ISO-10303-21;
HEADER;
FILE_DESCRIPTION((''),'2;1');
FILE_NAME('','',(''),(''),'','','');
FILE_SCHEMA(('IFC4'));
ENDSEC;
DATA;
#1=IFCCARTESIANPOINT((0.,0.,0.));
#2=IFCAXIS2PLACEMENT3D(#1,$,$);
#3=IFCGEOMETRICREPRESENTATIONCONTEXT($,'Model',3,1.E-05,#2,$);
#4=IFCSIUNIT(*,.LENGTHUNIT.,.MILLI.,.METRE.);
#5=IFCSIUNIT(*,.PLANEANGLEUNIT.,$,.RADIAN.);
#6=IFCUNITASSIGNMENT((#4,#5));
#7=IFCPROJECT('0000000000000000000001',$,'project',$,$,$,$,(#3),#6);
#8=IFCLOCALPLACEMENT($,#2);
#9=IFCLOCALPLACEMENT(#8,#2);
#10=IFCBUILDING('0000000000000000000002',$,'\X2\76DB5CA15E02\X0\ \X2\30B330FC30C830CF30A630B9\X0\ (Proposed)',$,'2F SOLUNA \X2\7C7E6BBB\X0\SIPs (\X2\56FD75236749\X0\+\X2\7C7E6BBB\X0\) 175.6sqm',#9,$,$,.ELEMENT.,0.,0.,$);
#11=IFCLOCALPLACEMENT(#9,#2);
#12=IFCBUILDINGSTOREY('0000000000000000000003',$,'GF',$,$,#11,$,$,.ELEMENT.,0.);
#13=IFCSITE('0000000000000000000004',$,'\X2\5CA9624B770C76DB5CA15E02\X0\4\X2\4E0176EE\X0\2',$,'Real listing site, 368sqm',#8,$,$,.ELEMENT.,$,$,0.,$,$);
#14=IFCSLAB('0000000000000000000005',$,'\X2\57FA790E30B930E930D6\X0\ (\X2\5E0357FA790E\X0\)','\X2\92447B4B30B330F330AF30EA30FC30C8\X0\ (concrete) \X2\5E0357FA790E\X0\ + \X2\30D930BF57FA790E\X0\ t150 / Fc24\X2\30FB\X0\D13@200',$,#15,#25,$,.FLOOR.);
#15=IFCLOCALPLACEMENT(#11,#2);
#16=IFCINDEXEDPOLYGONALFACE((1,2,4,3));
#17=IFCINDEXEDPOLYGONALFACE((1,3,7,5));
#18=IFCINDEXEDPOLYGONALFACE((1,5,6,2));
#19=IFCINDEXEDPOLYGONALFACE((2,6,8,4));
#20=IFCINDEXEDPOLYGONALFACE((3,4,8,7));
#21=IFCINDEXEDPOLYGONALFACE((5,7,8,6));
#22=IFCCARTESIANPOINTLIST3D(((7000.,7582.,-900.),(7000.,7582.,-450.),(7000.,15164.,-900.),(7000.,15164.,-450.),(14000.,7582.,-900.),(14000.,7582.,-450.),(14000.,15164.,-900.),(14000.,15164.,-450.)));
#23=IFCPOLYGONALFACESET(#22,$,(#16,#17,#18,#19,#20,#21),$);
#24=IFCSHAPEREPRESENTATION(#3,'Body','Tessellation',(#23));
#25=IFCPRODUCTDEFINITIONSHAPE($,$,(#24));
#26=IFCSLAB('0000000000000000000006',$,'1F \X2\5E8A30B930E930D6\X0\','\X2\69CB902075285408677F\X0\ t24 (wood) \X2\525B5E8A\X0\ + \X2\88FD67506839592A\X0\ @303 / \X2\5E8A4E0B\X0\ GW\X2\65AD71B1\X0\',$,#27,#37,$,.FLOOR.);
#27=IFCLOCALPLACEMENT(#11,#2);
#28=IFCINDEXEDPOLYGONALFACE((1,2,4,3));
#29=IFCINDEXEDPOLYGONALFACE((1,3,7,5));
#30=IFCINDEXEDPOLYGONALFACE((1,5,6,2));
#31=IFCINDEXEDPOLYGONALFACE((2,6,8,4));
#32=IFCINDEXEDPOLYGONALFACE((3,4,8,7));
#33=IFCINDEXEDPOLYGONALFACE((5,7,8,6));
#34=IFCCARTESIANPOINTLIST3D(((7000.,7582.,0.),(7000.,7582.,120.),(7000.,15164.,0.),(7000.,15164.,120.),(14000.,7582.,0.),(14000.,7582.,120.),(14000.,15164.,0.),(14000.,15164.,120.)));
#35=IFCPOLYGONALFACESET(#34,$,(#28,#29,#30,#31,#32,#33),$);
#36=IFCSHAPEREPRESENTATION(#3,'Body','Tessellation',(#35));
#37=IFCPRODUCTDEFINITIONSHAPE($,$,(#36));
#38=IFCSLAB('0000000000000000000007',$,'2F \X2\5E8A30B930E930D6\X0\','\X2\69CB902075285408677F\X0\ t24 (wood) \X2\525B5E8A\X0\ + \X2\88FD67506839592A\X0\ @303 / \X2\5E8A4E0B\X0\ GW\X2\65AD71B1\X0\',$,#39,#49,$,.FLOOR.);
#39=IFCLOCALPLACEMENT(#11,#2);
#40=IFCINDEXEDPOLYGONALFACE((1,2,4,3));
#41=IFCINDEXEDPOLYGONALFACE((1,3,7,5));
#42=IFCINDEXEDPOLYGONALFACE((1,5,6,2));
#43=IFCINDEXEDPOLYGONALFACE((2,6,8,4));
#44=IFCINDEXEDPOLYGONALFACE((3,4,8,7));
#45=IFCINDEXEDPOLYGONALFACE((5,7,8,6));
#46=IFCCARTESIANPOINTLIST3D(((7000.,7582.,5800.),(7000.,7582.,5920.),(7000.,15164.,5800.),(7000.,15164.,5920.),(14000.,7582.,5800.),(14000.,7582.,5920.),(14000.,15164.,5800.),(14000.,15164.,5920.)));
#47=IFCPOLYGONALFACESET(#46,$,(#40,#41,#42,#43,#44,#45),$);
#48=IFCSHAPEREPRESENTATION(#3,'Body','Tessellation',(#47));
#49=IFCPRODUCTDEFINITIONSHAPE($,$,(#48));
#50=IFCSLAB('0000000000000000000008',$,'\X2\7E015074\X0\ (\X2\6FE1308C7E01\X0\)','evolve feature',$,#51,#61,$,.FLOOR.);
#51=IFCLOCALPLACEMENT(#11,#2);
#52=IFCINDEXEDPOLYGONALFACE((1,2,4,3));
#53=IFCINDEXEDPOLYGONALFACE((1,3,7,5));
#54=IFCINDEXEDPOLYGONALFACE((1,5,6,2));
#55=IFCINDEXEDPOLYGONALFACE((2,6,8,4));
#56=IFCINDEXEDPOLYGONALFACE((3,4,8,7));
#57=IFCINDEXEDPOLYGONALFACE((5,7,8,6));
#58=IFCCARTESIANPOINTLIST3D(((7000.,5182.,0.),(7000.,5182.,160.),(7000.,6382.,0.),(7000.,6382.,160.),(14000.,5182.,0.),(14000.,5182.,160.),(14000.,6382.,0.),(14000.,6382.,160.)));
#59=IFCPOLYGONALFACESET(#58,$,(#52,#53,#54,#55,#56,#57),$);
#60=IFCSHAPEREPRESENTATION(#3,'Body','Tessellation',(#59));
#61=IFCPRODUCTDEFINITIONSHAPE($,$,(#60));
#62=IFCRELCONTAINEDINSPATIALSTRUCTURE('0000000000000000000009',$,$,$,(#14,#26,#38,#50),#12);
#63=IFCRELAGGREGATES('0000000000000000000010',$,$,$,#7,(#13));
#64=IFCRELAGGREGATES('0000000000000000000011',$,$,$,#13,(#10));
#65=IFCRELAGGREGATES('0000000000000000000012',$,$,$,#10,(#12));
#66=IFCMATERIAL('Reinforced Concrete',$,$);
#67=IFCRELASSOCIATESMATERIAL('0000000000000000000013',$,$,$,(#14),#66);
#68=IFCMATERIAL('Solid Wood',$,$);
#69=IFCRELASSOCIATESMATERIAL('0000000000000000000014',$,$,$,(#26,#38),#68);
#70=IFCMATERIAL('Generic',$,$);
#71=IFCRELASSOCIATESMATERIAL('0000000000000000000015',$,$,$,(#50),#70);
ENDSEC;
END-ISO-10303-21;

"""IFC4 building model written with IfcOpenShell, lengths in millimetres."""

from ifc_helpers import new_model, si_unit, frame, frame_2d, origin, place, context, project, spatial, rectangle, extrude, material, element, save


model = new_model("IFC4")

# Units and contexts
model_context = context("Model", 3, precision=1e-05, world=origin())
ifc_project = project(units=[si_unit("LENGTHUNIT", "METRE", prefix="MILLI"), si_unit("PLANEANGLEUNIT", "RADIAN")], contexts=[model_context])

# Site, building, storey
site_placement = place(None, origin())
site = spatial("IfcSite", under=ifc_project, at=site_placement, Name="岩手県盛岡市4丁目2", ObjectType="Real listing site, 368sqm", CompositionType="ELEMENT", RefElevation=0.0)
building_placement = place(site_placement, origin())
building = spatial("IfcBuilding", under=site, at=building_placement, Name="盛岡市 コートハウス (Proposed)", ObjectType="2F SOLUNA 籾殻SIPs (国産杉+籾殻) 175.6sqm", CompositionType="ELEMENT", ElevationOfRefHeight=0.0, ElevationOfTerrain=0.0)
storey_placement = place(building_placement, origin())
storey = spatial("IfcBuildingStorey", under=building, at=storey_placement, Name="GF", CompositionType="ELEMENT", Elevation=0.0)

# Slabs
ifc_material_1 = material(Name="Reinforced Concrete")
slab_1_placement = place(storey_placement, frame((3500.0, 3791.0, -450.0)))
element("IfcSlab", 1, at=slab_1_placement, inside=storey, material=ifc_material_1, Name="基礎スラブ (布基礎)", Description="鉄筋コンクリート (concrete) 布基礎 + ベタ基礎 t150 / Fc24・D13@200", PredefinedType="FLOOR", context=model_context, shape_type="SweptSolid", body=[
    extrude(rectangle(XDim=7000.0, YDim=7582.0, at=frame_2d((3500.0, 3791.0))), frame((3500.0, 3791.0, -450.0)), (0.0, 0.0, 1.0), 450.0),
])
ifc_material_2 = material(Name="Solid Wood")
slab_2_placement = place(storey_placement, frame((3500.0, 3791.0, 0.0)))
element("IfcSlab", 2, at=slab_2_placement, inside=storey, material=ifc_material_2, Name="1F 床スラブ", Description="構造用合板 t24 (wood) 剛床 + 製材根太 @303 / 床下 GW断熱", PredefinedType="FLOOR", context=model_context, shape_type="SweptSolid", body=[
    extrude(rectangle(XDim=7000.0, YDim=7582.0, at=frame_2d((3500.0, 3791.0))), frame((3500.0, 3791.0, 0.0)), (0.0, 0.0, 1.0), 120.0),
])
slab_3_placement = place(storey_placement, frame((3500.0, 3791.0, 2900.0)))
element("IfcSlab", 3, at=slab_3_placement, inside=storey, material=ifc_material_2, Name="2F 床スラブ", Description="構造用合板 t24 (wood) 剛床 + 製材根太 @303 / 床下 GW断熱", PredefinedType="FLOOR", context=model_context, shape_type="SweptSolid", body=[
    extrude(rectangle(XDim=7000.0, YDim=7582.0, at=frame_2d((3500.0, 3791.0))), frame((3500.0, 3791.0, 2900.0)), (0.0, 0.0, 1.0), 120.0),
])
ifc_material_3 = material(Name="Generic")
slab_4_placement = place(storey_placement, frame((3500.0, 2591.0, 0.0)))
element("IfcSlab", 4, at=slab_4_placement, inside=storey, material=ifc_material_3, Name="縁側 (濡れ縁)", Description="evolve feature", PredefinedType="FLOOR", context=model_context, shape_type="SweptSolid", body=[
    extrude(rectangle(XDim=7000.0, YDim=1200.0, at=frame_2d((3500.0, 600.0))), frame((3500.0, 2591.0, 0.0)), (0.0, 0.0, 1.0), 160.0),
])

save(model, "model.ifc")
